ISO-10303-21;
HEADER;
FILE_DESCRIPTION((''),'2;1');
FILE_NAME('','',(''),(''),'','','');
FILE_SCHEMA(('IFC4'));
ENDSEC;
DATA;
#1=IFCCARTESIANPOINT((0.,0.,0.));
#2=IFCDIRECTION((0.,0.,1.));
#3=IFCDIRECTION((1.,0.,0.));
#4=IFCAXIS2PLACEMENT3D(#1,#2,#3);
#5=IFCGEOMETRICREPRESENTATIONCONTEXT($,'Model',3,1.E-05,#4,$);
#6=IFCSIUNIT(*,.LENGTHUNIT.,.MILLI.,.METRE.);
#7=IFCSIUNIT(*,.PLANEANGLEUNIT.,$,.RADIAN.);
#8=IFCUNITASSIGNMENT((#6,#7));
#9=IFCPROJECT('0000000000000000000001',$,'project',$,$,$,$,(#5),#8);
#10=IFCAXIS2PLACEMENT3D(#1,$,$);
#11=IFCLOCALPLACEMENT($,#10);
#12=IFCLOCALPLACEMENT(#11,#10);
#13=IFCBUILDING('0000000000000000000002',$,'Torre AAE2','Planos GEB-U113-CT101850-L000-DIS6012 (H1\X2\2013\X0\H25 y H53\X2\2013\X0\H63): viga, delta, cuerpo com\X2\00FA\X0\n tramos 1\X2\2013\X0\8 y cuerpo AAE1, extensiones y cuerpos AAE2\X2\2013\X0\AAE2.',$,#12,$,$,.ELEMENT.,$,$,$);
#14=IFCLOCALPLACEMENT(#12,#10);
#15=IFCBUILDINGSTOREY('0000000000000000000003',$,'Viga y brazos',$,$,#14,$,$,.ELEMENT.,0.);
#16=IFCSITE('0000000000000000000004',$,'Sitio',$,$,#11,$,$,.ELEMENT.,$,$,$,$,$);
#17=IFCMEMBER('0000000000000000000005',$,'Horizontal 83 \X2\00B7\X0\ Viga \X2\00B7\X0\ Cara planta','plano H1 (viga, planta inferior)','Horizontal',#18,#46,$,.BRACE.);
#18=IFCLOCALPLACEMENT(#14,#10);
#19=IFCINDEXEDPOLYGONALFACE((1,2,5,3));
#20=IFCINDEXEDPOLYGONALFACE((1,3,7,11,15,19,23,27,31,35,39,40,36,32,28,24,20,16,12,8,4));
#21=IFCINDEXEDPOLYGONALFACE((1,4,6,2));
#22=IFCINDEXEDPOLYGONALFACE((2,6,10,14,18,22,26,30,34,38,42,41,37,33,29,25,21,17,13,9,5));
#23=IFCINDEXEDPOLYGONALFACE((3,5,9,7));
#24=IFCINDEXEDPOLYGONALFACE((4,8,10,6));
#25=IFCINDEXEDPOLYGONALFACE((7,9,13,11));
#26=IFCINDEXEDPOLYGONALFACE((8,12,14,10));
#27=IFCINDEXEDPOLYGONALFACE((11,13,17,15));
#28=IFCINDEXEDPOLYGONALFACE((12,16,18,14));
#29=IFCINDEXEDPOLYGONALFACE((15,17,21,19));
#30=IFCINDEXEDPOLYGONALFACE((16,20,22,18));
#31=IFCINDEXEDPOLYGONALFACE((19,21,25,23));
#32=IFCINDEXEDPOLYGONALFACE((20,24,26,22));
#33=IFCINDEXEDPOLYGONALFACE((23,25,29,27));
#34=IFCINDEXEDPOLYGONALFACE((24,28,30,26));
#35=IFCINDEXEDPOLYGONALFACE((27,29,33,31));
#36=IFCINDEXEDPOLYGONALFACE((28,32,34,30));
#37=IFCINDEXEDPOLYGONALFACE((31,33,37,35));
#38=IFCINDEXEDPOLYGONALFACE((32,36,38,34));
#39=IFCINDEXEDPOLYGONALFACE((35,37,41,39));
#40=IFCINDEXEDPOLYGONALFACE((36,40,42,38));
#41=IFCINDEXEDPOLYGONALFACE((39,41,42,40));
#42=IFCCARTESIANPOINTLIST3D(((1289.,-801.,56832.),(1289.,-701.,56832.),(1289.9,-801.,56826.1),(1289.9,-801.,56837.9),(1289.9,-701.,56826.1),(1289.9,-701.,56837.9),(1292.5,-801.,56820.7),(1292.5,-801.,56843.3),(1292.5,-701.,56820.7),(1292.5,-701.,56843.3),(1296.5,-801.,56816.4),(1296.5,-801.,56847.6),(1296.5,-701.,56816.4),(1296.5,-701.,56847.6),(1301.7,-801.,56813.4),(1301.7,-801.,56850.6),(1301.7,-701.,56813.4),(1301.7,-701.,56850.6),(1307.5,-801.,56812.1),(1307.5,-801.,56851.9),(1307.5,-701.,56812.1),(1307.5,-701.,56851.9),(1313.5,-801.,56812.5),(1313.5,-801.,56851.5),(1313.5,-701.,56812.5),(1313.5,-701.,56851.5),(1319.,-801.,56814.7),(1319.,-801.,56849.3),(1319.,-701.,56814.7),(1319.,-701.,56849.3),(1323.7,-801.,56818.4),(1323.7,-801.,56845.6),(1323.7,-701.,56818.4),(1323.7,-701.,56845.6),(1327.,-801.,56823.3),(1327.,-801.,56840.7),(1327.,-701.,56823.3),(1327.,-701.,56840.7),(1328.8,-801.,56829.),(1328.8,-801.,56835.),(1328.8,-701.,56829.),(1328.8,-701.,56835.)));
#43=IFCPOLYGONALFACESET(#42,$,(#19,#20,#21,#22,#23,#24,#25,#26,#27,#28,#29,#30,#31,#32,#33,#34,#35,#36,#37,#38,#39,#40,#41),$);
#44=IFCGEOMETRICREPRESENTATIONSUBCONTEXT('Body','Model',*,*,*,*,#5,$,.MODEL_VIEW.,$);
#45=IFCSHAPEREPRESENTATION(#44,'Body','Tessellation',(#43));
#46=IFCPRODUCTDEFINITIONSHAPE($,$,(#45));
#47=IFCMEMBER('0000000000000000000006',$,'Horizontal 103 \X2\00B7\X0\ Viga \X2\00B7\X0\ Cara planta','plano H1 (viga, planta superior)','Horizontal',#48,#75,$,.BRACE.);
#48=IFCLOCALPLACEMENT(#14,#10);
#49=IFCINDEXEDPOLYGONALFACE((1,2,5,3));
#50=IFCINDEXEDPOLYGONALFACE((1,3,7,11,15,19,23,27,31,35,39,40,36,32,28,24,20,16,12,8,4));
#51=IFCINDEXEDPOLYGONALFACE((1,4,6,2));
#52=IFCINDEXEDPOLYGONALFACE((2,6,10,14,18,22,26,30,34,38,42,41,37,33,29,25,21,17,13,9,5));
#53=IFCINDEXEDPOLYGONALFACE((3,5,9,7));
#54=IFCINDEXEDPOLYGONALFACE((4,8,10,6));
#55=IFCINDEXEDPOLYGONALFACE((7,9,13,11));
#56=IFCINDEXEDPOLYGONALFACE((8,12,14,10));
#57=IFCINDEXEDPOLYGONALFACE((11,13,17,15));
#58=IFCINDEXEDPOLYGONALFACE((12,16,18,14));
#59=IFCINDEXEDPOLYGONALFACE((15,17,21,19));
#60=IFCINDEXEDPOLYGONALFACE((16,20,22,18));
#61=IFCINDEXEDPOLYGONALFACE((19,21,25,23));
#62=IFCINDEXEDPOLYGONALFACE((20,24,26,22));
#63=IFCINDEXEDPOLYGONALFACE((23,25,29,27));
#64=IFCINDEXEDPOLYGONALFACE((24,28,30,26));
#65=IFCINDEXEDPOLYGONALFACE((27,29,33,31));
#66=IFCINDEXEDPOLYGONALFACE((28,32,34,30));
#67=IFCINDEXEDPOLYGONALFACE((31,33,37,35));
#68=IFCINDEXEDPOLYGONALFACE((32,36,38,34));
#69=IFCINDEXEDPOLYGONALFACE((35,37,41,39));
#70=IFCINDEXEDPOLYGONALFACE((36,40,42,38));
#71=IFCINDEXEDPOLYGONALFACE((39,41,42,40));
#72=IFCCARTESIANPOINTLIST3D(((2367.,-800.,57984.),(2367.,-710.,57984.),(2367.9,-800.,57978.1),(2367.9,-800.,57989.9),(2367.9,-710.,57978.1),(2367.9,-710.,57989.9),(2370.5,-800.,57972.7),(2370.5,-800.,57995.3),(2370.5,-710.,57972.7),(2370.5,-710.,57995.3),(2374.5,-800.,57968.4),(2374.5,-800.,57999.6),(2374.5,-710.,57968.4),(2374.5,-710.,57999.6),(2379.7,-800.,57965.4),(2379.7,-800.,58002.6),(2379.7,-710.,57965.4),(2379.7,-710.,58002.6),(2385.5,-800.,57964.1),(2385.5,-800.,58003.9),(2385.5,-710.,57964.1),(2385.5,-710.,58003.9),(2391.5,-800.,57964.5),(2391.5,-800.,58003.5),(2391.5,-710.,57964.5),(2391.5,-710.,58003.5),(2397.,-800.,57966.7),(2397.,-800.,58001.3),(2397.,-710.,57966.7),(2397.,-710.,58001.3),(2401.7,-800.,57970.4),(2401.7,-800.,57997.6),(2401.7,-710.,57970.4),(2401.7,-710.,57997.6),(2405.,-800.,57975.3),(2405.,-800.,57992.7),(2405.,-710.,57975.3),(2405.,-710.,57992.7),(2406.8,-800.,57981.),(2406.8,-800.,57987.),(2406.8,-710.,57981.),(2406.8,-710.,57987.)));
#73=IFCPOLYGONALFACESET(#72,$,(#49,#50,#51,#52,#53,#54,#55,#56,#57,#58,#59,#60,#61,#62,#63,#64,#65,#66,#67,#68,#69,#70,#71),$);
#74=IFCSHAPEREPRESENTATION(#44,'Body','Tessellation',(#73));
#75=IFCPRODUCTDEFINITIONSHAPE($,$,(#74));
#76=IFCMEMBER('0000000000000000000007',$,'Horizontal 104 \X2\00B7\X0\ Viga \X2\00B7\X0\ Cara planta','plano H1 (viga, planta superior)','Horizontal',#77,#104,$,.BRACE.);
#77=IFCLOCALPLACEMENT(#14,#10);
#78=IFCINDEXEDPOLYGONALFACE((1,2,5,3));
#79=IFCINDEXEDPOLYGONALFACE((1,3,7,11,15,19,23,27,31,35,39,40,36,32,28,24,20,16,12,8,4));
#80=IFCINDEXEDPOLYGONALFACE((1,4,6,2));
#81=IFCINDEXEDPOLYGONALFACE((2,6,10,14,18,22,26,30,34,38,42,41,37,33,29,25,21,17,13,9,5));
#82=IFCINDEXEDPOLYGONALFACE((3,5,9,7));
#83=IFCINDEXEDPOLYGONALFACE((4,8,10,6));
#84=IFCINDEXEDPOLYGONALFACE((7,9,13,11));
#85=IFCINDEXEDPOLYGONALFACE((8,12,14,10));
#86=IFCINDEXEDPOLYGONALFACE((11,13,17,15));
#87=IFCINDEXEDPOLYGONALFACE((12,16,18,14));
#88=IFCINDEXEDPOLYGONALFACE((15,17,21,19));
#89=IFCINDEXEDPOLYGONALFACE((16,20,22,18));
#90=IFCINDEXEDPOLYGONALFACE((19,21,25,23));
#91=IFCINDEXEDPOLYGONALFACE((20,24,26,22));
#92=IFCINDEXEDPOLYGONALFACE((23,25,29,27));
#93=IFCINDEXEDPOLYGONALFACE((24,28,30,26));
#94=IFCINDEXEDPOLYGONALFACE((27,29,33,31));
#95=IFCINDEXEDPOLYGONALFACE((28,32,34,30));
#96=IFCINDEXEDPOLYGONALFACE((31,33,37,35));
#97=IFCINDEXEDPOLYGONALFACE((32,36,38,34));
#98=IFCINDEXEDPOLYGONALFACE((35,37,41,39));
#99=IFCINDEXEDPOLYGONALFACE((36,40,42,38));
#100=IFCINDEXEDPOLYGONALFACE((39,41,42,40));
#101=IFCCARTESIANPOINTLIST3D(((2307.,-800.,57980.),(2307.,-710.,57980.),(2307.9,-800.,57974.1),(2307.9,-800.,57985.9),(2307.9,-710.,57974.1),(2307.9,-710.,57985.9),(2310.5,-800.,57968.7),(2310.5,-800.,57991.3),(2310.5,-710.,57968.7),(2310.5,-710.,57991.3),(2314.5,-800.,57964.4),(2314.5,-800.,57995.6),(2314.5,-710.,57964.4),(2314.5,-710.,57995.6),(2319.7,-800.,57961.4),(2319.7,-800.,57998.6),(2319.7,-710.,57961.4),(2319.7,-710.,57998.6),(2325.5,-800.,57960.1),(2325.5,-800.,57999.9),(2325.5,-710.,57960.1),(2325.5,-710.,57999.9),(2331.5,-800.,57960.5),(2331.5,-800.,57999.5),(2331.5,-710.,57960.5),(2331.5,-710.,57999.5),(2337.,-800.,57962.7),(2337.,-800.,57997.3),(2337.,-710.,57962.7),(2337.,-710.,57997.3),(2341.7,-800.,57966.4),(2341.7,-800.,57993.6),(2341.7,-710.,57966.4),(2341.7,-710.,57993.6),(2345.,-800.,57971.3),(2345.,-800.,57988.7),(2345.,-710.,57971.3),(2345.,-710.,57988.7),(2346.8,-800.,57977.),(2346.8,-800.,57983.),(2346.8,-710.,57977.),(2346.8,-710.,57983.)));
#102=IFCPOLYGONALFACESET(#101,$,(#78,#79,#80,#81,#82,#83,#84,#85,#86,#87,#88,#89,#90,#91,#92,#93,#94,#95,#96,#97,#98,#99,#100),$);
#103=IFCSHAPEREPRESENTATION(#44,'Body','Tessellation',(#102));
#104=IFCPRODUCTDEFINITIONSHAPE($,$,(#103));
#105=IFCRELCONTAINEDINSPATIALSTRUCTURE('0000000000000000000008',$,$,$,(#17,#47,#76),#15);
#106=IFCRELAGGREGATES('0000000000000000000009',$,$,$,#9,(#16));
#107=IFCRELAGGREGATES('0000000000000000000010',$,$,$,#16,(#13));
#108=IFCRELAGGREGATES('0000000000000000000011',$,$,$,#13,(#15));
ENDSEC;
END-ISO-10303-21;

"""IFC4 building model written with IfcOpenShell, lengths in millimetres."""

from ifc_helpers import new_model, si_unit, frame, origin, origin_with_axes, place, context, subcontext, project, spatial, circle, extrude, element, save


model = new_model("IFC4")

# Units and contexts
model_context = context("Model", 3, precision=1e-05, world=origin_with_axes())
body_context = subcontext(model_context, "Body", "Model", "MODEL_VIEW")
ifc_project = project(units=[si_unit("LENGTHUNIT", "METRE", prefix="MILLI"), si_unit("PLANEANGLEUNIT", "RADIAN")], contexts=[model_context])

# Site, building, storey
site_placement = place(None, origin())
site = spatial("IfcSite", under=ifc_project, at=site_placement, Name="Sitio", CompositionType="ELEMENT")
building_placement = place(site_placement, origin())
building = spatial("IfcBuilding", under=site, at=building_placement, Name="Torre AAE2", Description="Planos GEB-U113-CT101850-L000-DIS6012 (H1–H25 y H53–H63): viga, delta, cuerpo común tramos 1–8 y cuerpo AAE1, extensiones y cuerpos AAE2–AAE2.", CompositionType="ELEMENT")
storey_placement = place(building_placement, origin())
storey = spatial("IfcBuildingStorey", under=building, at=storey_placement, Name="Viga y brazos", CompositionType="ELEMENT", Elevation=0.0)

# Members
for number, where, z_axis, x_axis, name in (
    (1, (1309.0, -701.0, 56832.0), (0.0, -1.0, 0.0), (-1.0, 0.0, 0.0), "Horizontal 83 · Viga · Cara planta"),
):
    element("IfcMember", number, at=place(storey_placement, frame(where, z_axis=z_axis, x_axis=x_axis)), inside=storey, Name=name, Description="plano H1 (viga, planta inferior)", ObjectType="Horizontal", PredefinedType="BRACE", context=body_context, shape_type="SweptSolid", body=[
        extrude(circle(Radius=20.0), None, (0.0, 0.0, 1.0), 100.0),
    ])
for number, where, z_axis, x_axis, name in (
    (2, (2387.0, -710.0, 57984.0), (0.0, -1.0, 0.0), (-1.0, 0.0, 0.0), "Horizontal 103 · Viga · Cara planta"),
    (3, (2327.0, -710.0, 57980.0), (0.0, -1.0, 0.0), (-1.0, 0.0, 0.0), "Horizontal 104 · Viga · Cara planta"),
):
    element("IfcMember", number, at=place(storey_placement, frame(where, z_axis=z_axis, x_axis=x_axis)), inside=storey, Name=name, Description="plano H1 (viga, planta superior)", ObjectType="Horizontal", PredefinedType="BRACE", context=body_context, shape_type="SweptSolid", body=[
        extrude(circle(Radius=20.0), None, (0.0, 0.0, 1.0), 90.0),
    ])

save(model, "model.ifc")
